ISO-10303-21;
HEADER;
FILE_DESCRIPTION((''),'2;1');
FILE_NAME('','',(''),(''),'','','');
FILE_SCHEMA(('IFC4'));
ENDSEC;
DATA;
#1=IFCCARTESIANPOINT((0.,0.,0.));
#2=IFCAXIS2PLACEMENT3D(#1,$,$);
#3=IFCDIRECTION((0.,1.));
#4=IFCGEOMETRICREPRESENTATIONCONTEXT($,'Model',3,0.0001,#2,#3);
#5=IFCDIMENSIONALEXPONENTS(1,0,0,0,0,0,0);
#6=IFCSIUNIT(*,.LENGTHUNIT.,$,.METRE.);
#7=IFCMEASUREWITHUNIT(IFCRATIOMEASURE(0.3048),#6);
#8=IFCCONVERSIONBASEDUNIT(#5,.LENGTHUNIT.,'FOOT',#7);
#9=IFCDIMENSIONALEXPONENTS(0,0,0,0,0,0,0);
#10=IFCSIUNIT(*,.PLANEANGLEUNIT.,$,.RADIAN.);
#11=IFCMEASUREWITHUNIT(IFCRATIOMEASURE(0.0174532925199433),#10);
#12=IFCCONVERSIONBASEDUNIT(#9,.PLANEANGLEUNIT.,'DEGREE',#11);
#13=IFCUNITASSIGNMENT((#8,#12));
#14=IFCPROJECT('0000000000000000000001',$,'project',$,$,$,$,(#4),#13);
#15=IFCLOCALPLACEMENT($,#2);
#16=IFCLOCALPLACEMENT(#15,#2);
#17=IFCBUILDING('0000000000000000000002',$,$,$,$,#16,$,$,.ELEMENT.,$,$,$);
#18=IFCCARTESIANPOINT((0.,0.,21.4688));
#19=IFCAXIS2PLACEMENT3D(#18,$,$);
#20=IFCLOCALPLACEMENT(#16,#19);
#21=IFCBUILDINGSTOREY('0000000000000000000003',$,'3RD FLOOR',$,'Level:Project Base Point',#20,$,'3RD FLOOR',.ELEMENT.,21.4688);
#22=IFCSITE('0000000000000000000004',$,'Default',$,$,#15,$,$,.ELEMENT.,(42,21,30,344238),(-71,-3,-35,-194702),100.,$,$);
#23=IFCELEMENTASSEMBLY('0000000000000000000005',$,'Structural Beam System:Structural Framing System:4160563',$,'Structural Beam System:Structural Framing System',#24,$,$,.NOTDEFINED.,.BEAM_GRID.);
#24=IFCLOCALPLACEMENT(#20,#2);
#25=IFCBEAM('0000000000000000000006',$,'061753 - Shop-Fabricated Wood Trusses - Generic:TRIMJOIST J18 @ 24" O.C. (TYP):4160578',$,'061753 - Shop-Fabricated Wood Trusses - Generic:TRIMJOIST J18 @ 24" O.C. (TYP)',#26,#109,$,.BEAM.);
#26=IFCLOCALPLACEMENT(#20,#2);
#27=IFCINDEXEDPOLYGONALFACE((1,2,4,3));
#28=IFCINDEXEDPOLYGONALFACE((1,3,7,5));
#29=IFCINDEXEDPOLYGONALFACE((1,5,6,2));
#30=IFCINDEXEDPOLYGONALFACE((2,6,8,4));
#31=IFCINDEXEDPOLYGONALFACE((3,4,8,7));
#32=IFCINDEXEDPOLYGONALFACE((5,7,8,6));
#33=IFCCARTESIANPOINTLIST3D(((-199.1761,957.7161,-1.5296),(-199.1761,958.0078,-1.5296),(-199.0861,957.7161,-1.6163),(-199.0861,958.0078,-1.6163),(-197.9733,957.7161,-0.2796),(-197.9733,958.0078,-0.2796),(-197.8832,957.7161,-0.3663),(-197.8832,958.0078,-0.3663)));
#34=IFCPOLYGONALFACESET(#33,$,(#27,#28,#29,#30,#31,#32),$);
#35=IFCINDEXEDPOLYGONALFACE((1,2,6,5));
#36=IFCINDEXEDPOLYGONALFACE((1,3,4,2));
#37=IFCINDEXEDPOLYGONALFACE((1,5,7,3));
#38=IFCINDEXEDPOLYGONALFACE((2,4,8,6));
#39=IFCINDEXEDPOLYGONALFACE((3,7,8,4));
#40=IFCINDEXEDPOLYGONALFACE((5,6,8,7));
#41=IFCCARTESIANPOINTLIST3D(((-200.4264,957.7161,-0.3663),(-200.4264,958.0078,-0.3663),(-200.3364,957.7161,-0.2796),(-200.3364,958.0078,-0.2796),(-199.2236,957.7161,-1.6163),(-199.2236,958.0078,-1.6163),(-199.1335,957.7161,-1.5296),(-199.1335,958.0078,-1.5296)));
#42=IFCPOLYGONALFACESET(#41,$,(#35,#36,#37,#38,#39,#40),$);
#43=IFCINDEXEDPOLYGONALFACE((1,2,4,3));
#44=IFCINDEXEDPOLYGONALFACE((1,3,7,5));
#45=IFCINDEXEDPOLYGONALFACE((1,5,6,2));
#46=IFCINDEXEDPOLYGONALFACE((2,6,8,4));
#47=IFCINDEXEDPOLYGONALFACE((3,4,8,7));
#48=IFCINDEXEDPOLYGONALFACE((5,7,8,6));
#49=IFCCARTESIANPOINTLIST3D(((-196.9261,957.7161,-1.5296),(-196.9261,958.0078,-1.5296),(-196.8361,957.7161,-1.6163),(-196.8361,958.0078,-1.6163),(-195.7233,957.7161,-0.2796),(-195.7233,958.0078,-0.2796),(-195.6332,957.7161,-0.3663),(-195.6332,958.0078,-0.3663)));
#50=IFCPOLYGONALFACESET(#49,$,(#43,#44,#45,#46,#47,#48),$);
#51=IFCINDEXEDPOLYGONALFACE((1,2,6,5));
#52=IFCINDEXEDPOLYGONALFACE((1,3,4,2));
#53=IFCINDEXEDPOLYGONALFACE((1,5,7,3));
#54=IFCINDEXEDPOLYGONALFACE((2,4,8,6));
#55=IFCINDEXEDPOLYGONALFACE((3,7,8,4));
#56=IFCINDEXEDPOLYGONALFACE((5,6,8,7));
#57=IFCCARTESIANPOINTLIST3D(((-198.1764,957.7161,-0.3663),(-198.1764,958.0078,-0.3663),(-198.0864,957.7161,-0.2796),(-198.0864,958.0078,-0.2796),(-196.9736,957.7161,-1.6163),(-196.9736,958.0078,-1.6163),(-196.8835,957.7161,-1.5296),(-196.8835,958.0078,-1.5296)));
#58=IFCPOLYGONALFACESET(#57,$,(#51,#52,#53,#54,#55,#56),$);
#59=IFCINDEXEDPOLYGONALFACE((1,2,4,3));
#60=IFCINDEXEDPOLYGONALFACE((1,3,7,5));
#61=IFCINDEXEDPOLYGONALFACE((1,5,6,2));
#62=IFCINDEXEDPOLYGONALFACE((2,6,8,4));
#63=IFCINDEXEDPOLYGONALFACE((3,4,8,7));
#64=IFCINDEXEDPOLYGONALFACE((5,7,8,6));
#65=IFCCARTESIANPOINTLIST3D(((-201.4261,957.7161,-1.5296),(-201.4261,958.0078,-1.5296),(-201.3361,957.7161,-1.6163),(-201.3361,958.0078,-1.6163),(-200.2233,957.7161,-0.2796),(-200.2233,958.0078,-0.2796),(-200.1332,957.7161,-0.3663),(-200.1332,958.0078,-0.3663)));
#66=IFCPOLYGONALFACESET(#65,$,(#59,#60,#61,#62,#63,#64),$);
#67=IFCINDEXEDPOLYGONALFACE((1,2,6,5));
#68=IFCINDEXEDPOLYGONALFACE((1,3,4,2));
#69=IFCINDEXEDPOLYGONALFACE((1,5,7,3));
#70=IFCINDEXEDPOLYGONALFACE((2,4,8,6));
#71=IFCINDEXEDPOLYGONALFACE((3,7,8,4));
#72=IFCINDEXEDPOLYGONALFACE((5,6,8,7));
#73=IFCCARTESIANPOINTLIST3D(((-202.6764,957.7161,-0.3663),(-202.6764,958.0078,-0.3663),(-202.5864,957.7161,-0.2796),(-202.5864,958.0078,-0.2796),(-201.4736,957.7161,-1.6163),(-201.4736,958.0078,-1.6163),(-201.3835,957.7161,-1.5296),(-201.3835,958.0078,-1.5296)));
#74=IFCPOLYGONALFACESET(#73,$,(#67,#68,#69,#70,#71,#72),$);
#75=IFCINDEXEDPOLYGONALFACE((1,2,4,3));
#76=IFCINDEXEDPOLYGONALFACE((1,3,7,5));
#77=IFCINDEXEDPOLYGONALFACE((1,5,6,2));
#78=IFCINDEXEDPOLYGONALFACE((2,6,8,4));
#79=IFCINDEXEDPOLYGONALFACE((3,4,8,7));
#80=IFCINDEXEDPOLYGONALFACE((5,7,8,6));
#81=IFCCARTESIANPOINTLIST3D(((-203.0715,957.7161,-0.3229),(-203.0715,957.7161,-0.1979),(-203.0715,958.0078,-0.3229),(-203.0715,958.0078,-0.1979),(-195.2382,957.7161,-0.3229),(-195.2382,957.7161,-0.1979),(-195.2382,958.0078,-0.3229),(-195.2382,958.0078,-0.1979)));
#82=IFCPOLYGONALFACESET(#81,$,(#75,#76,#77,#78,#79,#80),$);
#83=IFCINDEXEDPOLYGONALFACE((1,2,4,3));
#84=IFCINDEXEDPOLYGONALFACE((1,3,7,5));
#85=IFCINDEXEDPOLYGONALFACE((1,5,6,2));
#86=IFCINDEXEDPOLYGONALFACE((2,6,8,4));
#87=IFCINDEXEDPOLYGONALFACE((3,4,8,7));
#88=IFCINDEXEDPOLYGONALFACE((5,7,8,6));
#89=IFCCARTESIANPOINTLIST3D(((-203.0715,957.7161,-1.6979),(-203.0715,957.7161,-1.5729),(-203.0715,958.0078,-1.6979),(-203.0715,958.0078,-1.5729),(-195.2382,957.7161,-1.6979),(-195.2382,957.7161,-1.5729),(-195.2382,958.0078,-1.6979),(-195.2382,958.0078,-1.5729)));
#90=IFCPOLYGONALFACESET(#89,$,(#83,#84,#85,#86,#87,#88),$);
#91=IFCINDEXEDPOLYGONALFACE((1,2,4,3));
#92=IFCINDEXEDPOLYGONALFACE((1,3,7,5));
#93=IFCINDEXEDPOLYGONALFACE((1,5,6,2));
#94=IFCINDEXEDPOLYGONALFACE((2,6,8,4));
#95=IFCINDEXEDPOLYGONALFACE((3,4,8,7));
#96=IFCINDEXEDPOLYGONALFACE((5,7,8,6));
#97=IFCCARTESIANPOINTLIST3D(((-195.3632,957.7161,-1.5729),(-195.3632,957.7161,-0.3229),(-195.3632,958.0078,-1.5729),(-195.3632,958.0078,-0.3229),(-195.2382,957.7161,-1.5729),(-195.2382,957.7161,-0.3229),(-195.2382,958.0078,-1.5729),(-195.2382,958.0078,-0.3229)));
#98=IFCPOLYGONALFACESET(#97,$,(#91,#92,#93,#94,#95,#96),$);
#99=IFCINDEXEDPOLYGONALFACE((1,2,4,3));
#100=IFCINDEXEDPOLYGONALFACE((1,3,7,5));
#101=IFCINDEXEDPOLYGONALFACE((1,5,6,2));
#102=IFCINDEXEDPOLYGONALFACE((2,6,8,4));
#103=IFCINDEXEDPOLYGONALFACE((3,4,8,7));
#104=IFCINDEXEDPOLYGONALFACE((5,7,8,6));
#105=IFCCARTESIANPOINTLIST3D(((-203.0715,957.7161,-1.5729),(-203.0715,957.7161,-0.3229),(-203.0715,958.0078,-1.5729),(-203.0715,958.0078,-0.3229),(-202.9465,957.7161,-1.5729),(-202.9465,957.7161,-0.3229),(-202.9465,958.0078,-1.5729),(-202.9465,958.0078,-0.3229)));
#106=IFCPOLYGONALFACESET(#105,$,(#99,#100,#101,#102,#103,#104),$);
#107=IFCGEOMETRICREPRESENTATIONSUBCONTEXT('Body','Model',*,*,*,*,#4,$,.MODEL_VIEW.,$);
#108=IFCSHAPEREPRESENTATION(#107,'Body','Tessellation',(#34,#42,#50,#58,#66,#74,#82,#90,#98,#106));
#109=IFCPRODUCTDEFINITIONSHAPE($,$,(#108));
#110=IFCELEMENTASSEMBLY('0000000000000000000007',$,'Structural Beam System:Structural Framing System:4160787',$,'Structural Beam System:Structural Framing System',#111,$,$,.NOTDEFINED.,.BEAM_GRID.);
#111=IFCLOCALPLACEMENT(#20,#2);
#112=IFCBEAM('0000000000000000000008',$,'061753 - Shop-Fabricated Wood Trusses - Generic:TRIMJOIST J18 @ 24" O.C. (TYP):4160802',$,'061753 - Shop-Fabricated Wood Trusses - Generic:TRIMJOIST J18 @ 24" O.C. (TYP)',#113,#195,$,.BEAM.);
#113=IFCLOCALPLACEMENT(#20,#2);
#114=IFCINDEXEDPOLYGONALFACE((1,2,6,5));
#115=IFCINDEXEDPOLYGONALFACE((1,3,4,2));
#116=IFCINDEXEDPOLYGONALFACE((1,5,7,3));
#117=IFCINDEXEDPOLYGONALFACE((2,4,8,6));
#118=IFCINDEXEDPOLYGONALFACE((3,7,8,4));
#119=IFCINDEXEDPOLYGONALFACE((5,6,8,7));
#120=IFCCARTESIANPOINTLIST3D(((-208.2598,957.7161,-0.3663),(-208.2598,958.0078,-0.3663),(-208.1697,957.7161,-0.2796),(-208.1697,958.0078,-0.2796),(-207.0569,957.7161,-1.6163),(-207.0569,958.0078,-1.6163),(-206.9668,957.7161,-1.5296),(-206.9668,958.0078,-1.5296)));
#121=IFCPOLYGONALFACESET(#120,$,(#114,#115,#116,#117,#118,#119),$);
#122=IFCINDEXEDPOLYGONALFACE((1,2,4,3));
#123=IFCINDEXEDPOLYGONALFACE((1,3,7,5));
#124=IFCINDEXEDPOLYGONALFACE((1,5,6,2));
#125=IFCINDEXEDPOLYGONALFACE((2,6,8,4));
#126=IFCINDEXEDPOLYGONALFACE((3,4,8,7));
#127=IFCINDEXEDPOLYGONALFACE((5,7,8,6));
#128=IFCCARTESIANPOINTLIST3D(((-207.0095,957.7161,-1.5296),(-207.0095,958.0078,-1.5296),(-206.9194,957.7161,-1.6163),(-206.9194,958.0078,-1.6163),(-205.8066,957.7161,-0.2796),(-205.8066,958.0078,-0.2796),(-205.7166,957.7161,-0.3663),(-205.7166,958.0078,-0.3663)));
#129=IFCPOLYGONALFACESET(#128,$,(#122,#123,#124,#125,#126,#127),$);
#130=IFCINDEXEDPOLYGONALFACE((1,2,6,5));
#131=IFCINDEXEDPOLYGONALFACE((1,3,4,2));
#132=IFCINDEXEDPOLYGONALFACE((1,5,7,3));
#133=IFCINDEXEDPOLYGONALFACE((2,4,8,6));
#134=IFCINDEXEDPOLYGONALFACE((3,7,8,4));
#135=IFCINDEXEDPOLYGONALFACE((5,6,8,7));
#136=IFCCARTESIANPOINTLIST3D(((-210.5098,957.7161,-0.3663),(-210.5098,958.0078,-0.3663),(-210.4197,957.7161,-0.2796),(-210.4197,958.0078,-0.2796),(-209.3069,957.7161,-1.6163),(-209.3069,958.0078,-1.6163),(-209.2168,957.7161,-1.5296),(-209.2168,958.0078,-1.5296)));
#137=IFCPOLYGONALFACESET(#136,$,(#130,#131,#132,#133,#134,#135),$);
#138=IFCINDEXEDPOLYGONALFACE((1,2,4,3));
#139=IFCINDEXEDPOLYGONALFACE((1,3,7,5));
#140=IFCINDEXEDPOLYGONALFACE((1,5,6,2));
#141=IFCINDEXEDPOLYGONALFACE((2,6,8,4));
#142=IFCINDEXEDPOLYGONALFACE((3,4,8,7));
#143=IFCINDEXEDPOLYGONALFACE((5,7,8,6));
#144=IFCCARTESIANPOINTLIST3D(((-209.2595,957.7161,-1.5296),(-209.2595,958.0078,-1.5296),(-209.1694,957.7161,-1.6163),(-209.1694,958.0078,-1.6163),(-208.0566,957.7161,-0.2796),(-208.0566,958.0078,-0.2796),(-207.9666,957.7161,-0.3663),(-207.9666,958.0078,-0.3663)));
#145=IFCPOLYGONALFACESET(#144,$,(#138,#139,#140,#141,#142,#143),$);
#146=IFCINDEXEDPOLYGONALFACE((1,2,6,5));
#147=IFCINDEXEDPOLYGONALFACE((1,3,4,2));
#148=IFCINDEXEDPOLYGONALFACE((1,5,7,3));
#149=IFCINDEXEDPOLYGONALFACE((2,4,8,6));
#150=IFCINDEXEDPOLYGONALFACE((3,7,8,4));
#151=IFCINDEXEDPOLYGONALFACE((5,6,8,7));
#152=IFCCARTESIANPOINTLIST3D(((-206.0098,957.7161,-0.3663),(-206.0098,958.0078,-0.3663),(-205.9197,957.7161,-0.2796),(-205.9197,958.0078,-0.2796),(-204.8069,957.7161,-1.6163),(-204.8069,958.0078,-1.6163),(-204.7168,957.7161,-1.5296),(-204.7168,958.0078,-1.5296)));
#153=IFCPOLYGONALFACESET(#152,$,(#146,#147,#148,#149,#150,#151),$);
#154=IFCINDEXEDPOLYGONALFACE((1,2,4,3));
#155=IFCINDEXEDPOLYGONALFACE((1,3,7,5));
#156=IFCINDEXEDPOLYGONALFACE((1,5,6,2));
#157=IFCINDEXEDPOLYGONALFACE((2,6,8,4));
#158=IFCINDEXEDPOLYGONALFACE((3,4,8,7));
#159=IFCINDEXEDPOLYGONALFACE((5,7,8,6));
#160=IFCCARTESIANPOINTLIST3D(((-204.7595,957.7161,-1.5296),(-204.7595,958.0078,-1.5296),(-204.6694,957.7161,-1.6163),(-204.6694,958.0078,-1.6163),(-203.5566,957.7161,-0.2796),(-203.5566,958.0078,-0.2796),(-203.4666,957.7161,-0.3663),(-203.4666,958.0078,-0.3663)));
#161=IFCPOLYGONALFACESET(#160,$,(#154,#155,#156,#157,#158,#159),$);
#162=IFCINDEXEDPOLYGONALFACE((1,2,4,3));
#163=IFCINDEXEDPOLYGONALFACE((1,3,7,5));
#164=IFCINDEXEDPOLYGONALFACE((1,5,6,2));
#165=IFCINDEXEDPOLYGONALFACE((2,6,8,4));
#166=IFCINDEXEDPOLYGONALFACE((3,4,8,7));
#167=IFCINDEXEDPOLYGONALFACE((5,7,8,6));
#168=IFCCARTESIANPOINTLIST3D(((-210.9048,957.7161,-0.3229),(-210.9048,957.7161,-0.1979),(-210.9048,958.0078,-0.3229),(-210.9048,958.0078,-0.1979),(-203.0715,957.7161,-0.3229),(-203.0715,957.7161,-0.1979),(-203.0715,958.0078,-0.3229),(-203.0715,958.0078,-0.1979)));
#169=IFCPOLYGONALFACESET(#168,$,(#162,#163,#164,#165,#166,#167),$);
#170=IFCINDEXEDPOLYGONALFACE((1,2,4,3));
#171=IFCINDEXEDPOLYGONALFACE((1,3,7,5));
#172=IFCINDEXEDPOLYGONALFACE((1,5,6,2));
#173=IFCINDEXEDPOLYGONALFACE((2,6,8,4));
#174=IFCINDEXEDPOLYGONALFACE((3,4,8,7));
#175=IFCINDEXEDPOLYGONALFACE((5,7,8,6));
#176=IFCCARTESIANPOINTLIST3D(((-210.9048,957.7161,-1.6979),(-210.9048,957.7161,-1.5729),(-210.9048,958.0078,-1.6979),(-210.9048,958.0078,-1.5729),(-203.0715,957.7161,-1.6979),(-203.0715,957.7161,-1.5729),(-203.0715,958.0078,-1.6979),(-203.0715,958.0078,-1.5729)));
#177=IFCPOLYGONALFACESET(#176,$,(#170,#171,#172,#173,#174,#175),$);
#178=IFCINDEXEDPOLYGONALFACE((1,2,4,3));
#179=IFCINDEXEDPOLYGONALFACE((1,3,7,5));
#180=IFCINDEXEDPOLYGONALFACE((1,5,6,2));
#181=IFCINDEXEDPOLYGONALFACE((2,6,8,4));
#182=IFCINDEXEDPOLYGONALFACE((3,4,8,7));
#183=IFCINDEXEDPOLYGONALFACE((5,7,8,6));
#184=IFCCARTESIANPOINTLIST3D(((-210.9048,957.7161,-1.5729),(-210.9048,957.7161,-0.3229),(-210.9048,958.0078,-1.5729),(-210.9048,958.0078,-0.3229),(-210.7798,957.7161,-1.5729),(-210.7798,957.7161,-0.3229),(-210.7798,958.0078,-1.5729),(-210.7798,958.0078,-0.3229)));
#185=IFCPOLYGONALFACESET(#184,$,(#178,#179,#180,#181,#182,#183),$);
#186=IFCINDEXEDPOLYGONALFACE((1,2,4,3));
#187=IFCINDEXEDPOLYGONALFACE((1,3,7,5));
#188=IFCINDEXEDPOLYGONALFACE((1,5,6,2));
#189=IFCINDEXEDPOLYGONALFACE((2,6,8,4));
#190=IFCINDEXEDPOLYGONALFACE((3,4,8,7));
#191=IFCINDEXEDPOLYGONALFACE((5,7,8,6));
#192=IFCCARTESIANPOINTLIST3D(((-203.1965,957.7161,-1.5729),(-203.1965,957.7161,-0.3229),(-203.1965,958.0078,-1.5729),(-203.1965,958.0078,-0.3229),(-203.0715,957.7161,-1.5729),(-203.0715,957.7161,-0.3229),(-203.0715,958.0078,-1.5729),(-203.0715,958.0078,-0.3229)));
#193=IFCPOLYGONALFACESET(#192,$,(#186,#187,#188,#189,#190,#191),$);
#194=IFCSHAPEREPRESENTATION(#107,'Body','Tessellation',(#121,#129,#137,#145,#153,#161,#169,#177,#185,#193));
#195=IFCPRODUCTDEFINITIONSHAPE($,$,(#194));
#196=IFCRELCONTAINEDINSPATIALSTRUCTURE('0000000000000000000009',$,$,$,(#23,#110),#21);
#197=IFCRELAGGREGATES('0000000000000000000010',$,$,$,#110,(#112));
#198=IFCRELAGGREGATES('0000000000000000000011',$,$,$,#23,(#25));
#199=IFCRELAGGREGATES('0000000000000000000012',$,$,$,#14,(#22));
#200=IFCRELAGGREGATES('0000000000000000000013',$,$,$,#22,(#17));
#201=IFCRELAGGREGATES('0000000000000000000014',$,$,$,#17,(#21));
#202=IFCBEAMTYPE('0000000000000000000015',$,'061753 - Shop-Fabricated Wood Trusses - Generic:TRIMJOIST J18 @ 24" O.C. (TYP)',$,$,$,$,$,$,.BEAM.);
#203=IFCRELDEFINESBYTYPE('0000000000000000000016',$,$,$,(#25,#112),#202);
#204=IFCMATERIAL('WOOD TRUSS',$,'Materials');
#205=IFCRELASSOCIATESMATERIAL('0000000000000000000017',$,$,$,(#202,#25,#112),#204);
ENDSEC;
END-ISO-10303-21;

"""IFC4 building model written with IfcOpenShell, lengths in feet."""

from ifc_helpers import new_model, entity, si_unit, converted_unit, direction, frame, frame_2d, origin, origin_2d_with_axis, place, context, subcontext, project, spatial, rectangle, extrude, source, transform, mapped, material, material_profile, profile_set, profile_usage, type_object, type_shapes, element, aggregate, save


model = new_model("IFC4")

# Units and contexts
model_context = context("Model", 3, precision=0.0001, world=origin(), true_north=direction((0.0, 1.0)))
body_context = subcontext(model_context, "Body", "Model", "MODEL_VIEW")
ifc_project = project(units=[converted_unit("LENGTHUNIT", "FOOT", entity("IfcRatioMeasure", 0.3048), si_unit("LENGTHUNIT", "METRE"), dimensions=[1, 0, 0, 0, 0, 0, 0]), converted_unit("PLANEANGLEUNIT", "DEGREE", entity("IfcRatioMeasure", 0.0174532925199433), si_unit("PLANEANGLEUNIT", "RADIAN"), dimensions=[0, 0, 0, 0, 0, 0, 0])], contexts=[model_context])

# Site, building, storey
site_placement = place(None, origin())
site = spatial("IfcSite", under=ifc_project, at=site_placement, Name="Default", CompositionType="ELEMENT", RefLatitude=(42, 21, 30, 344238), RefLongitude=(-71, -3, -35, -194702), RefElevation=100.0)
building_placement = place(site_placement, origin())
building = spatial("IfcBuilding", under=site, at=building_placement, CompositionType="ELEMENT")
storey_placement = place(building_placement, frame((0.0, 0.0, 21.4688)))
storey = spatial("IfcBuildingStorey", under=building, at=storey_placement, Name="3RD FLOOR", ObjectType="Level:Project Base Point", LongName="3RD FLOOR", CompositionType="ELEMENT", Elevation=21.4688)

# Shared definitions
ifc_material_1 = material(Name="WOOD TRUSS", Category="Materials")
ifc_material_profile_1 = material_profile(ifc_material_1, rectangle(XDim=1.7347, YDim=0.125, at=frame_2d((0.0, 0.0), x_axis=(1.0, 0.0))), Name="TRIMJOIST J18 @ 24\" O.C. (TYP)")
ifc_material_profile_2 = material_profile(ifc_material_1, rectangle(XDim=1.7347, YDim=0.125, at=frame_2d((0.0, 0.0), x_axis=(1.0, 0.0))), Name="TRIMJOIST J18 @ 24\" O.C. (TYP)")
ifc_material_profile_3 = material_profile(ifc_material_1, rectangle(XDim=1.7347, YDim=0.125, at=frame_2d((0.0, 0.0), x_axis=(1.0, 0.0))), Name="TRIMJOIST J18 @ 24\" O.C. (TYP)")
ifc_material_profile_4 = material_profile(ifc_material_1, rectangle(XDim=1.7347, YDim=0.125, at=frame_2d((0.0, 0.0), x_axis=(1.0, 0.0))), Name="TRIMJOIST J18 @ 24\" O.C. (TYP)")
ifc_material_profile_5 = material_profile(ifc_material_1, rectangle(XDim=1.7347, YDim=0.125, at=frame_2d((0.0, 0.0), x_axis=(1.0, 0.0))), Name="TRIMJOIST J18 @ 24\" O.C. (TYP)")
ifc_material_profile_6 = material_profile(ifc_material_1, rectangle(XDim=1.7347, YDim=0.125, at=frame_2d((0.0, 0.0), x_axis=(1.0, 0.0))), Name="TRIMJOIST J18 @ 24\" O.C. (TYP)")
ifc_material_profile_7 = material_profile(ifc_material_1, rectangle(XDim=1.7347, YDim=0.125, at=frame_2d((0.0, 0.0), x_axis=(1.0, 0.0))), Name="TRIMJOIST J18 @ 24\" O.C. (TYP)")
ifc_material_profile_8 = material_profile(ifc_material_1, rectangle(XDim=1.7347, YDim=0.125, at=frame_2d((0.0, 0.0), x_axis=(1.0, 0.0))), Name="TRIMJOIST J18 @ 24\" O.C. (TYP)")
ifc_material_profile_9 = material_profile(ifc_material_1, rectangle(XDim=1.7347, YDim=0.125, at=frame_2d((0.0, 0.0), x_axis=(1.0, 0.0))), Name="TRIMJOIST J18 @ 24\" O.C. (TYP)")
ifc_material_profile_10 = material_profile(ifc_material_1, rectangle(XDim=1.7347, YDim=0.125, at=origin_2d_with_axis()), Name="TRIMJOIST J18 @ 24\" O.C. (TYP)")
ifc_material_profile_11 = material_profile(ifc_material_1, rectangle(XDim=0.125, YDim=0.2917, at=origin_2d_with_axis()), Name="TRIMJOIST J18 @ 24\" O.C. (TYP)")
ifc_material_profile_12 = material_profile(ifc_material_1, rectangle(XDim=0.125, YDim=0.2917, at=origin_2d_with_axis()), Name="TRIMJOIST J18 @ 24\" O.C. (TYP)")
ifc_material_profile_13 = material_profile(ifc_material_1, rectangle(XDim=1.25, YDim=0.2917, at=origin_2d_with_axis()), Name="TRIMJOIST J18 @ 24\" O.C. (TYP)")
ifc_material_profile_14 = material_profile(ifc_material_1, rectangle(XDim=1.25, YDim=0.2917, at=origin_2d_with_axis()), Name="TRIMJOIST J18 @ 24\" O.C. (TYP)")
ifc_profile_set_1 = profile_set([ifc_material_profile_1, ifc_material_profile_2, ifc_material_profile_3, ifc_material_profile_4, ifc_material_profile_5, ifc_material_profile_6, ifc_material_profile_7, ifc_material_profile_8, ifc_material_profile_9, ifc_material_profile_10, ifc_material_profile_11, ifc_material_profile_12, ifc_material_profile_13, ifc_material_profile_14], Name="TRIMJOIST J18 @ 24\" O.C. (TYP)")

# Element assembly, beam
assembly_1_placement = place(storey_placement, origin())
assembly_1 = element("IfcElementAssembly", 1, at=assembly_1_placement, inside=storey, Name="Structural Beam System:Structural Framing System:4160563", ObjectType="Structural Beam System:Structural Framing System", AssemblyPlace="NOTDEFINED", PredefinedType="BEAM_GRID")
ifc_profile_usage_1 = profile_usage(ifc_profile_set_1, cardinal=8)
beam_type_1 = type_object("IfcBeamType", Name="061753 - Shop-Fabricated Wood Trusses - Generic:TRIMJOIST J18 @ 24\" O.C. (TYP)", PredefinedType="BEAM", material=ifc_profile_set_1)
shared_shape_1 = source(origin(), body_context, "Body", "SweptSolid", [
    extrude(rectangle(XDim=1.7347, YDim=0.125, at=frame_2d((0.0, 0.0), x_axis=(1.0, 0.0))), frame((0.6251, -0.1458, 0.0), z_axis=(0.0, 1.0, 0.0), x_axis=(0.693383, 0.0, 0.720569)), (0.0, 0.0, 1.0), 0.2917),
    extrude(rectangle(XDim=1.7347, YDim=0.125, at=frame_2d((0.0, 0.0), x_axis=(1.0, 0.0))), frame((-0.6251, -0.1458, 0.0), z_axis=(0.0, 1.0, 0.0), x_axis=(0.693383, 0.0, -0.720569)), (0.0, 0.0, 1.0), 0.2917),
    extrude(rectangle(XDim=1.7347, YDim=0.125, at=frame_2d((0.0, 0.0), x_axis=(1.0, 0.0))), frame((2.8751, -0.1458, 0.0), z_axis=(0.0, 1.0, 0.0), x_axis=(0.693383, 0.0, 0.720569)), (0.0, 0.0, 1.0), 0.2917),
    extrude(rectangle(XDim=1.7347, YDim=0.125, at=frame_2d((0.0, 0.0), x_axis=(1.0, 0.0))), frame((1.6249, -0.1458, 0.0), z_axis=(0.0, 1.0, 0.0), x_axis=(0.693383, 0.0, -0.720569)), (0.0, 0.0, 1.0), 0.2917),
    extrude(rectangle(XDim=1.7347, YDim=0.125, at=frame_2d((0.0, 0.0), x_axis=(1.0, 0.0))), frame((-1.6249, -0.1458, 0.0), z_axis=(0.0, 1.0, 0.0), x_axis=(0.693383, 0.0, 0.720569)), (0.0, 0.0, 1.0), 0.2917),
    extrude(rectangle(XDim=1.7347, YDim=0.125, at=origin_2d_with_axis()), frame((-2.8751, -0.1458, 0.0), z_axis=(0.0, 1.0, 0.0), x_axis=(0.693383, 0.0, -0.720569)), (0.0, 0.0, 1.0), 0.2917),
    extrude(rectangle(XDim=0.125, YDim=0.2917, at=origin_2d_with_axis()), frame((-3.9167, 0.0, 0.6875), z_axis=(1.0, 0.0, 0.0), x_axis=(0.0, 0.0, -1.0)), (0.0, 0.0, 1.0), 7.8333),
    extrude(rectangle(XDim=0.125, YDim=0.2917, at=origin_2d_with_axis()), frame((-3.9167, 0.0, -0.6875), z_axis=(1.0, 0.0, 0.0), x_axis=(0.0, 0.0, -1.0)), (0.0, 0.0, 1.0), 7.8333),
    extrude(rectangle(XDim=1.25, YDim=0.2917, at=origin_2d_with_axis()), frame((3.7917, 0.0, 0.0), z_axis=(1.0, 0.0, 0.0), x_axis=(0.0, 0.0, -1.0)), (0.0, 0.0, 1.0), 0.125),
    extrude(rectangle(XDim=1.25, YDim=0.2917, at=origin_2d_with_axis()), frame((-3.9167, 0.0, 0.0), z_axis=(1.0, 0.0, 0.0), x_axis=(0.0, 0.0, -1.0)), (0.0, 0.0, 1.0), 0.125),
])
type_shapes(beam_type_1, [shared_shape_1])
beam_1_placement = place(assembly_1_placement, frame((-199.1548, 957.8619, -0.9479)))
beam_1 = element("IfcBeam", 2, at=beam_1_placement, type_object=beam_type_1, material=ifc_profile_usage_1, Name="061753 - Shop-Fabricated Wood Trusses - Generic:TRIMJOIST J18 @ 24\" O.C. (TYP):4160578", ObjectType="061753 - Shop-Fabricated Wood Trusses - Generic:TRIMJOIST J18 @ 24\" O.C. (TYP)", PredefinedType="BEAM", context=body_context, shape_type="MappedRepresentation", body=[
    mapped(shared_shape_1, transform((0.0, 0.0, 0.0), scale=1.0)),
])

# Element assembly, beam
assembly_2_placement = place(storey_placement, origin())
assembly_2 = element("IfcElementAssembly", 3, at=assembly_2_placement, inside=storey, Name="Structural Beam System:Structural Framing System:4160787", ObjectType="Structural Beam System:Structural Framing System", AssemblyPlace="NOTDEFINED", PredefinedType="BEAM_GRID")
ifc_profile_usage_2 = profile_usage(ifc_profile_set_1, cardinal=8)
beam_2_placement = place(assembly_2_placement, frame((-206.9882, 957.8619, -0.9479), z_axis=(0.0, 0.0, 1.0), x_axis=(-1.0, 0.0, 0.0)))
beam_2 = element("IfcBeam", 4, at=beam_2_placement, type_object=beam_type_1, material=ifc_profile_usage_2, Name="061753 - Shop-Fabricated Wood Trusses - Generic:TRIMJOIST J18 @ 24\" O.C. (TYP):4160802", ObjectType="061753 - Shop-Fabricated Wood Trusses - Generic:TRIMJOIST J18 @ 24\" O.C. (TYP)", PredefinedType="BEAM", context=body_context, shape_type="MappedRepresentation", body=[
    mapped(shared_shape_1, transform((0.0, 0.0, 0.0), scale=1.0)),
])
aggregate(assembly_2, [beam_2])

aggregate(assembly_1, [beam_1])

save(model, "model.ifc")
